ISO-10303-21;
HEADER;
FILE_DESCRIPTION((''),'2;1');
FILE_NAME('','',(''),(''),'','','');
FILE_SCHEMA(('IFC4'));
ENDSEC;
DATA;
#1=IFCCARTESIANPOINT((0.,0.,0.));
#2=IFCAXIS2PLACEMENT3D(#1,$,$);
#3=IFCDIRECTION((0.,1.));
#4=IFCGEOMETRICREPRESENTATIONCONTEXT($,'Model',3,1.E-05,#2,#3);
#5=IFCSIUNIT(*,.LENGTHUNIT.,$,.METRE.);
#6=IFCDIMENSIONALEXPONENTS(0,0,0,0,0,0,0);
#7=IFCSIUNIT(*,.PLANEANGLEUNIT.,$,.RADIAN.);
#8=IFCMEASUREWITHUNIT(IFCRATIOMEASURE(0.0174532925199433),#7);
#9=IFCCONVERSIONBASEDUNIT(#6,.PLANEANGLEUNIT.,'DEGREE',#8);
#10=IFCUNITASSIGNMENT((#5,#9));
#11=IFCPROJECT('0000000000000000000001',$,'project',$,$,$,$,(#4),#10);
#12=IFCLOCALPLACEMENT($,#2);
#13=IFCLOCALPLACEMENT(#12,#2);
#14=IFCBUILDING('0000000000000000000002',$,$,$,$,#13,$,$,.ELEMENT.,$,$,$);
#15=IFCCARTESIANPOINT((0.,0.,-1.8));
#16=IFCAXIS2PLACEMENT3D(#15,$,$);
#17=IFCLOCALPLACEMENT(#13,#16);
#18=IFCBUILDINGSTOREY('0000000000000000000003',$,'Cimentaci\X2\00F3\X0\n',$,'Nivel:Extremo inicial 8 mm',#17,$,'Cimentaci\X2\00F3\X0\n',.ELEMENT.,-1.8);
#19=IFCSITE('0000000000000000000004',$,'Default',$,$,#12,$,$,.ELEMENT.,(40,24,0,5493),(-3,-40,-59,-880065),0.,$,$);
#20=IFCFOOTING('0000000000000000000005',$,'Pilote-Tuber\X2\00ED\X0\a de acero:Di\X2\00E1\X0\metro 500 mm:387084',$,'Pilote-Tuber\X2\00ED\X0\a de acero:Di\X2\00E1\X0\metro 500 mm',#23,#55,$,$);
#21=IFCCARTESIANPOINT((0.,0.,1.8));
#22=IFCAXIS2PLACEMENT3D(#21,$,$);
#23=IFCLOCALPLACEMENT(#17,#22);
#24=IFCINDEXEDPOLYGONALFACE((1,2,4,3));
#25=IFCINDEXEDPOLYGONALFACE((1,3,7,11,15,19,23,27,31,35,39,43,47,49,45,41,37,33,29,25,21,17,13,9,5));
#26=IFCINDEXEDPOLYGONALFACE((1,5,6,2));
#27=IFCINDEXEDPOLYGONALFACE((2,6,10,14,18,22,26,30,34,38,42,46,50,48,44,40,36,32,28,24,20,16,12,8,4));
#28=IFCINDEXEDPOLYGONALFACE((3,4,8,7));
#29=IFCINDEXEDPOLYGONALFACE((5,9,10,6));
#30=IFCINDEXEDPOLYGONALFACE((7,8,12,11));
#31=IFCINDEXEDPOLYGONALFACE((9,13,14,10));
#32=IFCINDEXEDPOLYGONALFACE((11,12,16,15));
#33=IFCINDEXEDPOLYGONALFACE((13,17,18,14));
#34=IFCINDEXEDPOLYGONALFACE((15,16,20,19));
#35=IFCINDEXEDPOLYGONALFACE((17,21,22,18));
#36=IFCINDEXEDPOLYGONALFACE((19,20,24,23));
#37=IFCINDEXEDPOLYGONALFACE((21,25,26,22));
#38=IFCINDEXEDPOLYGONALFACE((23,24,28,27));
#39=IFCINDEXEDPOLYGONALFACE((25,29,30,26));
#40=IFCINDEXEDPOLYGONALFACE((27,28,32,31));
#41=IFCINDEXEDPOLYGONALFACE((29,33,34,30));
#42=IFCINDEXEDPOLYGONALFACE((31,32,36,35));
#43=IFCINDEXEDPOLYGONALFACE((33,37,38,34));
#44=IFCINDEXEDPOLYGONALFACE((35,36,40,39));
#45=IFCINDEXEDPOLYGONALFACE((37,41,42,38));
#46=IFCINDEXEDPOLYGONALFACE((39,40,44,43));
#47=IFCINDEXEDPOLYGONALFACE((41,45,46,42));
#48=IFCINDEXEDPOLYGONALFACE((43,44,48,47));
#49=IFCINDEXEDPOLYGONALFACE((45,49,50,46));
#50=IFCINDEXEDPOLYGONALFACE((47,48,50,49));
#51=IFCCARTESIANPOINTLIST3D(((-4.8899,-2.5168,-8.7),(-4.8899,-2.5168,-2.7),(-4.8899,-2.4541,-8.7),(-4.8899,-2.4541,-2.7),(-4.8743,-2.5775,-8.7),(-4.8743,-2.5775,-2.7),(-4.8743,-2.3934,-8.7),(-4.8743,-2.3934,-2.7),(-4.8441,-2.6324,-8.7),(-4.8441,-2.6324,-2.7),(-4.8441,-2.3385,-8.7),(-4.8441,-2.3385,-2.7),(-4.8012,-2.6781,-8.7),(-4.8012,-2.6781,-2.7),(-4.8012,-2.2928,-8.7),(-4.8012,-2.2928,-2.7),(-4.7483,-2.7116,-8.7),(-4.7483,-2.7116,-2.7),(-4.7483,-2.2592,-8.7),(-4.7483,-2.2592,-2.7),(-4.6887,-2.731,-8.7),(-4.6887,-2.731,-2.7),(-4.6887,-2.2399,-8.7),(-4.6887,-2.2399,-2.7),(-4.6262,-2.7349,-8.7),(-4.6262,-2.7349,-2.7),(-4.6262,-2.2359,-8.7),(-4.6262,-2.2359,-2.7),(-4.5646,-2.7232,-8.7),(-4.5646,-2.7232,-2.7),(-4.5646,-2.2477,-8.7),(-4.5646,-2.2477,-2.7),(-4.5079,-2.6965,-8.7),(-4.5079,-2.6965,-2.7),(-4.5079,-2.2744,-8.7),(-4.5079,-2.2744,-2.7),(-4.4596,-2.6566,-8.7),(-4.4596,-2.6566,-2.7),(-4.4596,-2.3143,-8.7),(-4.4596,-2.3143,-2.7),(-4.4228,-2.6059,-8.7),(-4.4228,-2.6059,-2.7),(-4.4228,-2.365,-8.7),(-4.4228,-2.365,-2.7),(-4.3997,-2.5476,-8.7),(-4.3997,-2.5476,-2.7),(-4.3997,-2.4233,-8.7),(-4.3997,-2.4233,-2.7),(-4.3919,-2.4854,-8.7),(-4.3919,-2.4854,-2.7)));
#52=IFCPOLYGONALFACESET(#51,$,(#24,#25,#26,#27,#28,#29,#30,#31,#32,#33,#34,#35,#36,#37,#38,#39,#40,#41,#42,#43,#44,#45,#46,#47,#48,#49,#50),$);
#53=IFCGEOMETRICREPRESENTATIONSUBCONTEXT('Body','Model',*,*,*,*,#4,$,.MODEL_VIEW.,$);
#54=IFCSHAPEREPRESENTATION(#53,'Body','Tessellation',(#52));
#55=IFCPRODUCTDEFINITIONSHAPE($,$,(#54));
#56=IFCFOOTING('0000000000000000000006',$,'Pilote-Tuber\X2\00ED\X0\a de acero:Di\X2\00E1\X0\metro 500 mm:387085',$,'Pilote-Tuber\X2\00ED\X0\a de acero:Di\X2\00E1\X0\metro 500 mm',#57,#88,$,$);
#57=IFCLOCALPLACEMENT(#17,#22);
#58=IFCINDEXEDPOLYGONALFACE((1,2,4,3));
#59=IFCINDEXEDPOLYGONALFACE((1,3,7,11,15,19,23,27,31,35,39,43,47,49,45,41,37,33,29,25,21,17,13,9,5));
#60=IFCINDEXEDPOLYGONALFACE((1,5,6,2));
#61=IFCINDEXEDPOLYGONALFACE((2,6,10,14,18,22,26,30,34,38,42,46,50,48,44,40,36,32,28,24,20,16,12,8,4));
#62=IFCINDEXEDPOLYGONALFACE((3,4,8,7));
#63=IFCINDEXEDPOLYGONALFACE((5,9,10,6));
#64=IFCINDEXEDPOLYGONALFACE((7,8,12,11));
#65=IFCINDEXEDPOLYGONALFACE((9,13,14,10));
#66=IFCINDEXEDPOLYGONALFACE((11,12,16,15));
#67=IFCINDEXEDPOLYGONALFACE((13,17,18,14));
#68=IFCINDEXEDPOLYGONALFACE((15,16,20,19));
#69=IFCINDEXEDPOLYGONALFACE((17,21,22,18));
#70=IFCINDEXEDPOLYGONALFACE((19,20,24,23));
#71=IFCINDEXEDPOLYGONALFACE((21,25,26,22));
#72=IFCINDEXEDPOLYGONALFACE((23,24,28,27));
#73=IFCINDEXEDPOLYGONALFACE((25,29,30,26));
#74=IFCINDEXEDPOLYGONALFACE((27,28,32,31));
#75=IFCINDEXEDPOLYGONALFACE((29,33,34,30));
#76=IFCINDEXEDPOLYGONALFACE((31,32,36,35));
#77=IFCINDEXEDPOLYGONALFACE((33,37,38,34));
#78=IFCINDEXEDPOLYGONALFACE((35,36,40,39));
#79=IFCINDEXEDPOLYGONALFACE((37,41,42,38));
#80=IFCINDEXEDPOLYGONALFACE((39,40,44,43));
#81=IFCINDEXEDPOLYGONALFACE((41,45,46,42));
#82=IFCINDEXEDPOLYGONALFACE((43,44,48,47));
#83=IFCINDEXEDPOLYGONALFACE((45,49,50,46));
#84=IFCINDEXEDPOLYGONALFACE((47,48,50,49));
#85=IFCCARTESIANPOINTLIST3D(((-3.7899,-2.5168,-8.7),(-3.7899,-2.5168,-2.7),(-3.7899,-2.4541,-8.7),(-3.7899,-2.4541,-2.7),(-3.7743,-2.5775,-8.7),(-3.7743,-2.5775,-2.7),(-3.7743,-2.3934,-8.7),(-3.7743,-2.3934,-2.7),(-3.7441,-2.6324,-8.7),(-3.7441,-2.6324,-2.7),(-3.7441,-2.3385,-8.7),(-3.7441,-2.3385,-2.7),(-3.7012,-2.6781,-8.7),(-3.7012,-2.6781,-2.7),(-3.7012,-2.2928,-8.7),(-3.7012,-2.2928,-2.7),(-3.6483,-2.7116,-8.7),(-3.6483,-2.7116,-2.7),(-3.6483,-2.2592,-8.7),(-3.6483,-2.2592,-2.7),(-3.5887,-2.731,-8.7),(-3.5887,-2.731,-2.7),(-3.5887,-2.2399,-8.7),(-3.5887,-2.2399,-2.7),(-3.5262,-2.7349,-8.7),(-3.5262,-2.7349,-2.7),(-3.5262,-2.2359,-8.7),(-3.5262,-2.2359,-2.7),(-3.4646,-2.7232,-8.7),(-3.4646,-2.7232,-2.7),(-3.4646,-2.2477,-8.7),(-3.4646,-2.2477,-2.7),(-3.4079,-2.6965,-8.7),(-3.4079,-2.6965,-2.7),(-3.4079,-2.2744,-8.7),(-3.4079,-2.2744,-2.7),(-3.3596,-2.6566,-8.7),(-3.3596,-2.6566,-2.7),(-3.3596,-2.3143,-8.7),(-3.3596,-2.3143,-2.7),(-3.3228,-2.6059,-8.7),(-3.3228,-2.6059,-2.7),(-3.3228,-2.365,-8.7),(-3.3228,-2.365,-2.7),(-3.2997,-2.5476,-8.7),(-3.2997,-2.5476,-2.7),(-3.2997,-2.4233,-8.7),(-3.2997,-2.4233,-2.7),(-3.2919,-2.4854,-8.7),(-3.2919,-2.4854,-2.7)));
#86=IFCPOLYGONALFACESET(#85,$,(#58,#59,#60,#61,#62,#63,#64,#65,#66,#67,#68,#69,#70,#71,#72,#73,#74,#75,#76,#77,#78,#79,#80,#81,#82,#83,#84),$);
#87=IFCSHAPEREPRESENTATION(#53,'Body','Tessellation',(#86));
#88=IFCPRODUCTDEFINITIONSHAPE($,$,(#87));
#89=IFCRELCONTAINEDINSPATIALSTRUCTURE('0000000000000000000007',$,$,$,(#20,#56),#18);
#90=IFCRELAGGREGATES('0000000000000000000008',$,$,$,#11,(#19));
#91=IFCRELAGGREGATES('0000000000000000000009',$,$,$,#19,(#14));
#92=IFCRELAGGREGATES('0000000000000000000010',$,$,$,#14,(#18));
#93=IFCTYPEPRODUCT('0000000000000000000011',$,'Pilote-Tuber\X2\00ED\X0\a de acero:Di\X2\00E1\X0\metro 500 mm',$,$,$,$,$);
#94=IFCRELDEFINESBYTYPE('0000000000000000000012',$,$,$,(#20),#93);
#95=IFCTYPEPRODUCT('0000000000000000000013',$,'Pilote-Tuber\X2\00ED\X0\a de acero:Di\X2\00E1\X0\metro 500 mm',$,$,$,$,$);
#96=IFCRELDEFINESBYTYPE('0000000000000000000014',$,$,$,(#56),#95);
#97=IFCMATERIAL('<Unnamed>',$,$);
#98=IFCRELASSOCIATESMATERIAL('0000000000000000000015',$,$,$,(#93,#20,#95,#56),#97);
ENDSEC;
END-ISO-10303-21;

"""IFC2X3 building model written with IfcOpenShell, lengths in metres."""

from ifc_helpers import new_model, entity, si_unit, converted_unit, direction, frame, frame_2d, origin, origin_2d_with_axis, place, context, subcontext, project, spatial, circle, extrude, source, transform, mapped, material, type_object, type_shapes, element, save


model = new_model("IFC2X3")

# Units and contexts
model_context = context("Model", 3, precision=1e-05, world=origin(), true_north=direction((0.0, 1.0)))
body_context = subcontext(model_context, "Body", "Model", "MODEL_VIEW")
ifc_project = project(units=[si_unit("LENGTHUNIT", "METRE"), converted_unit("PLANEANGLEUNIT", "DEGREE", entity("IfcRatioMeasure", 0.0174532925199433), si_unit("PLANEANGLEUNIT", "RADIAN"), dimensions=[0, 0, 0, 0, 0, 0, 0])], contexts=[model_context])

# Site, building, storey
site_placement = place(None, origin())
site = spatial("IfcSite", under=ifc_project, at=site_placement, Name="Default", CompositionType="ELEMENT", RefLatitude=(40, 24, 0, 5493), RefLongitude=(-3, -40, -59, -880065), RefElevation=0.0)
building_placement = place(site_placement, origin())
building = spatial("IfcBuilding", under=site, at=building_placement, CompositionType="ELEMENT")
storey_placement = place(building_placement, frame((0.0, 0.0, -1.8)))
storey = spatial("IfcBuildingStorey", under=building, at=storey_placement, Name="Cimentación", ObjectType="Nivel:Extremo inicial 8 mm", LongName="Cimentación", CompositionType="ELEMENT", Elevation=-1.8)

# Footings
ifc_material_1 = material(Name="<Unnamed>")
type_product_1 = type_object("IfcTypeProduct", Name="Pilote-Tubería de acero:Diámetro 500 mm", material=ifc_material_1)
shared_shape_1 = source(origin(), body_context, "Body", "SweptSolid", [
    extrude(circle(Radius=0.25, at=frame_2d((0.0, 0.0), x_axis=(1.0, 0.0))), frame((-4.6419, -2.4854, -8.7)), (0.0, 0.0, 1.0), 6.0),
])
type_shapes(type_product_1, [shared_shape_1])
footing_1_placement = place(storey_placement, frame((0.0, 0.0, 1.8)))
element("IfcFooting", 1, at=footing_1_placement, inside=storey, type_object=type_product_1, material=ifc_material_1, Name="Pilote-Tubería de acero:Diámetro 500 mm:387084", ObjectType="Pilote-Tubería de acero:Diámetro 500 mm", context=body_context, shape_type="MappedRepresentation", body=[
    mapped(shared_shape_1, transform((0.0, 0.0, 0.0), scale=1.0)),
])
type_product_2 = type_object("IfcTypeProduct", Name="Pilote-Tubería de acero:Diámetro 500 mm", material=ifc_material_1)
shared_shape_2 = source(origin(), body_context, "Body", "SweptSolid", [
    extrude(circle(Radius=0.25, at=origin_2d_with_axis()), frame((-3.5419, -2.4854, -8.7)), (0.0, 0.0, 1.0), 6.0),
])
type_shapes(type_product_2, [shared_shape_2])
footing_2_placement = place(storey_placement, frame((0.0, 0.0, 1.8)))
element("IfcFooting", 2, at=footing_2_placement, inside=storey, type_object=type_product_2, material=ifc_material_1, Name="Pilote-Tubería de acero:Diámetro 500 mm:387085", ObjectType="Pilote-Tubería de acero:Diámetro 500 mm", context=body_context, shape_type="MappedRepresentation", body=[
    mapped(shared_shape_2, transform((0.0, 0.0, 0.0), scale=1.0)),
])

save(model, "model.ifc")
